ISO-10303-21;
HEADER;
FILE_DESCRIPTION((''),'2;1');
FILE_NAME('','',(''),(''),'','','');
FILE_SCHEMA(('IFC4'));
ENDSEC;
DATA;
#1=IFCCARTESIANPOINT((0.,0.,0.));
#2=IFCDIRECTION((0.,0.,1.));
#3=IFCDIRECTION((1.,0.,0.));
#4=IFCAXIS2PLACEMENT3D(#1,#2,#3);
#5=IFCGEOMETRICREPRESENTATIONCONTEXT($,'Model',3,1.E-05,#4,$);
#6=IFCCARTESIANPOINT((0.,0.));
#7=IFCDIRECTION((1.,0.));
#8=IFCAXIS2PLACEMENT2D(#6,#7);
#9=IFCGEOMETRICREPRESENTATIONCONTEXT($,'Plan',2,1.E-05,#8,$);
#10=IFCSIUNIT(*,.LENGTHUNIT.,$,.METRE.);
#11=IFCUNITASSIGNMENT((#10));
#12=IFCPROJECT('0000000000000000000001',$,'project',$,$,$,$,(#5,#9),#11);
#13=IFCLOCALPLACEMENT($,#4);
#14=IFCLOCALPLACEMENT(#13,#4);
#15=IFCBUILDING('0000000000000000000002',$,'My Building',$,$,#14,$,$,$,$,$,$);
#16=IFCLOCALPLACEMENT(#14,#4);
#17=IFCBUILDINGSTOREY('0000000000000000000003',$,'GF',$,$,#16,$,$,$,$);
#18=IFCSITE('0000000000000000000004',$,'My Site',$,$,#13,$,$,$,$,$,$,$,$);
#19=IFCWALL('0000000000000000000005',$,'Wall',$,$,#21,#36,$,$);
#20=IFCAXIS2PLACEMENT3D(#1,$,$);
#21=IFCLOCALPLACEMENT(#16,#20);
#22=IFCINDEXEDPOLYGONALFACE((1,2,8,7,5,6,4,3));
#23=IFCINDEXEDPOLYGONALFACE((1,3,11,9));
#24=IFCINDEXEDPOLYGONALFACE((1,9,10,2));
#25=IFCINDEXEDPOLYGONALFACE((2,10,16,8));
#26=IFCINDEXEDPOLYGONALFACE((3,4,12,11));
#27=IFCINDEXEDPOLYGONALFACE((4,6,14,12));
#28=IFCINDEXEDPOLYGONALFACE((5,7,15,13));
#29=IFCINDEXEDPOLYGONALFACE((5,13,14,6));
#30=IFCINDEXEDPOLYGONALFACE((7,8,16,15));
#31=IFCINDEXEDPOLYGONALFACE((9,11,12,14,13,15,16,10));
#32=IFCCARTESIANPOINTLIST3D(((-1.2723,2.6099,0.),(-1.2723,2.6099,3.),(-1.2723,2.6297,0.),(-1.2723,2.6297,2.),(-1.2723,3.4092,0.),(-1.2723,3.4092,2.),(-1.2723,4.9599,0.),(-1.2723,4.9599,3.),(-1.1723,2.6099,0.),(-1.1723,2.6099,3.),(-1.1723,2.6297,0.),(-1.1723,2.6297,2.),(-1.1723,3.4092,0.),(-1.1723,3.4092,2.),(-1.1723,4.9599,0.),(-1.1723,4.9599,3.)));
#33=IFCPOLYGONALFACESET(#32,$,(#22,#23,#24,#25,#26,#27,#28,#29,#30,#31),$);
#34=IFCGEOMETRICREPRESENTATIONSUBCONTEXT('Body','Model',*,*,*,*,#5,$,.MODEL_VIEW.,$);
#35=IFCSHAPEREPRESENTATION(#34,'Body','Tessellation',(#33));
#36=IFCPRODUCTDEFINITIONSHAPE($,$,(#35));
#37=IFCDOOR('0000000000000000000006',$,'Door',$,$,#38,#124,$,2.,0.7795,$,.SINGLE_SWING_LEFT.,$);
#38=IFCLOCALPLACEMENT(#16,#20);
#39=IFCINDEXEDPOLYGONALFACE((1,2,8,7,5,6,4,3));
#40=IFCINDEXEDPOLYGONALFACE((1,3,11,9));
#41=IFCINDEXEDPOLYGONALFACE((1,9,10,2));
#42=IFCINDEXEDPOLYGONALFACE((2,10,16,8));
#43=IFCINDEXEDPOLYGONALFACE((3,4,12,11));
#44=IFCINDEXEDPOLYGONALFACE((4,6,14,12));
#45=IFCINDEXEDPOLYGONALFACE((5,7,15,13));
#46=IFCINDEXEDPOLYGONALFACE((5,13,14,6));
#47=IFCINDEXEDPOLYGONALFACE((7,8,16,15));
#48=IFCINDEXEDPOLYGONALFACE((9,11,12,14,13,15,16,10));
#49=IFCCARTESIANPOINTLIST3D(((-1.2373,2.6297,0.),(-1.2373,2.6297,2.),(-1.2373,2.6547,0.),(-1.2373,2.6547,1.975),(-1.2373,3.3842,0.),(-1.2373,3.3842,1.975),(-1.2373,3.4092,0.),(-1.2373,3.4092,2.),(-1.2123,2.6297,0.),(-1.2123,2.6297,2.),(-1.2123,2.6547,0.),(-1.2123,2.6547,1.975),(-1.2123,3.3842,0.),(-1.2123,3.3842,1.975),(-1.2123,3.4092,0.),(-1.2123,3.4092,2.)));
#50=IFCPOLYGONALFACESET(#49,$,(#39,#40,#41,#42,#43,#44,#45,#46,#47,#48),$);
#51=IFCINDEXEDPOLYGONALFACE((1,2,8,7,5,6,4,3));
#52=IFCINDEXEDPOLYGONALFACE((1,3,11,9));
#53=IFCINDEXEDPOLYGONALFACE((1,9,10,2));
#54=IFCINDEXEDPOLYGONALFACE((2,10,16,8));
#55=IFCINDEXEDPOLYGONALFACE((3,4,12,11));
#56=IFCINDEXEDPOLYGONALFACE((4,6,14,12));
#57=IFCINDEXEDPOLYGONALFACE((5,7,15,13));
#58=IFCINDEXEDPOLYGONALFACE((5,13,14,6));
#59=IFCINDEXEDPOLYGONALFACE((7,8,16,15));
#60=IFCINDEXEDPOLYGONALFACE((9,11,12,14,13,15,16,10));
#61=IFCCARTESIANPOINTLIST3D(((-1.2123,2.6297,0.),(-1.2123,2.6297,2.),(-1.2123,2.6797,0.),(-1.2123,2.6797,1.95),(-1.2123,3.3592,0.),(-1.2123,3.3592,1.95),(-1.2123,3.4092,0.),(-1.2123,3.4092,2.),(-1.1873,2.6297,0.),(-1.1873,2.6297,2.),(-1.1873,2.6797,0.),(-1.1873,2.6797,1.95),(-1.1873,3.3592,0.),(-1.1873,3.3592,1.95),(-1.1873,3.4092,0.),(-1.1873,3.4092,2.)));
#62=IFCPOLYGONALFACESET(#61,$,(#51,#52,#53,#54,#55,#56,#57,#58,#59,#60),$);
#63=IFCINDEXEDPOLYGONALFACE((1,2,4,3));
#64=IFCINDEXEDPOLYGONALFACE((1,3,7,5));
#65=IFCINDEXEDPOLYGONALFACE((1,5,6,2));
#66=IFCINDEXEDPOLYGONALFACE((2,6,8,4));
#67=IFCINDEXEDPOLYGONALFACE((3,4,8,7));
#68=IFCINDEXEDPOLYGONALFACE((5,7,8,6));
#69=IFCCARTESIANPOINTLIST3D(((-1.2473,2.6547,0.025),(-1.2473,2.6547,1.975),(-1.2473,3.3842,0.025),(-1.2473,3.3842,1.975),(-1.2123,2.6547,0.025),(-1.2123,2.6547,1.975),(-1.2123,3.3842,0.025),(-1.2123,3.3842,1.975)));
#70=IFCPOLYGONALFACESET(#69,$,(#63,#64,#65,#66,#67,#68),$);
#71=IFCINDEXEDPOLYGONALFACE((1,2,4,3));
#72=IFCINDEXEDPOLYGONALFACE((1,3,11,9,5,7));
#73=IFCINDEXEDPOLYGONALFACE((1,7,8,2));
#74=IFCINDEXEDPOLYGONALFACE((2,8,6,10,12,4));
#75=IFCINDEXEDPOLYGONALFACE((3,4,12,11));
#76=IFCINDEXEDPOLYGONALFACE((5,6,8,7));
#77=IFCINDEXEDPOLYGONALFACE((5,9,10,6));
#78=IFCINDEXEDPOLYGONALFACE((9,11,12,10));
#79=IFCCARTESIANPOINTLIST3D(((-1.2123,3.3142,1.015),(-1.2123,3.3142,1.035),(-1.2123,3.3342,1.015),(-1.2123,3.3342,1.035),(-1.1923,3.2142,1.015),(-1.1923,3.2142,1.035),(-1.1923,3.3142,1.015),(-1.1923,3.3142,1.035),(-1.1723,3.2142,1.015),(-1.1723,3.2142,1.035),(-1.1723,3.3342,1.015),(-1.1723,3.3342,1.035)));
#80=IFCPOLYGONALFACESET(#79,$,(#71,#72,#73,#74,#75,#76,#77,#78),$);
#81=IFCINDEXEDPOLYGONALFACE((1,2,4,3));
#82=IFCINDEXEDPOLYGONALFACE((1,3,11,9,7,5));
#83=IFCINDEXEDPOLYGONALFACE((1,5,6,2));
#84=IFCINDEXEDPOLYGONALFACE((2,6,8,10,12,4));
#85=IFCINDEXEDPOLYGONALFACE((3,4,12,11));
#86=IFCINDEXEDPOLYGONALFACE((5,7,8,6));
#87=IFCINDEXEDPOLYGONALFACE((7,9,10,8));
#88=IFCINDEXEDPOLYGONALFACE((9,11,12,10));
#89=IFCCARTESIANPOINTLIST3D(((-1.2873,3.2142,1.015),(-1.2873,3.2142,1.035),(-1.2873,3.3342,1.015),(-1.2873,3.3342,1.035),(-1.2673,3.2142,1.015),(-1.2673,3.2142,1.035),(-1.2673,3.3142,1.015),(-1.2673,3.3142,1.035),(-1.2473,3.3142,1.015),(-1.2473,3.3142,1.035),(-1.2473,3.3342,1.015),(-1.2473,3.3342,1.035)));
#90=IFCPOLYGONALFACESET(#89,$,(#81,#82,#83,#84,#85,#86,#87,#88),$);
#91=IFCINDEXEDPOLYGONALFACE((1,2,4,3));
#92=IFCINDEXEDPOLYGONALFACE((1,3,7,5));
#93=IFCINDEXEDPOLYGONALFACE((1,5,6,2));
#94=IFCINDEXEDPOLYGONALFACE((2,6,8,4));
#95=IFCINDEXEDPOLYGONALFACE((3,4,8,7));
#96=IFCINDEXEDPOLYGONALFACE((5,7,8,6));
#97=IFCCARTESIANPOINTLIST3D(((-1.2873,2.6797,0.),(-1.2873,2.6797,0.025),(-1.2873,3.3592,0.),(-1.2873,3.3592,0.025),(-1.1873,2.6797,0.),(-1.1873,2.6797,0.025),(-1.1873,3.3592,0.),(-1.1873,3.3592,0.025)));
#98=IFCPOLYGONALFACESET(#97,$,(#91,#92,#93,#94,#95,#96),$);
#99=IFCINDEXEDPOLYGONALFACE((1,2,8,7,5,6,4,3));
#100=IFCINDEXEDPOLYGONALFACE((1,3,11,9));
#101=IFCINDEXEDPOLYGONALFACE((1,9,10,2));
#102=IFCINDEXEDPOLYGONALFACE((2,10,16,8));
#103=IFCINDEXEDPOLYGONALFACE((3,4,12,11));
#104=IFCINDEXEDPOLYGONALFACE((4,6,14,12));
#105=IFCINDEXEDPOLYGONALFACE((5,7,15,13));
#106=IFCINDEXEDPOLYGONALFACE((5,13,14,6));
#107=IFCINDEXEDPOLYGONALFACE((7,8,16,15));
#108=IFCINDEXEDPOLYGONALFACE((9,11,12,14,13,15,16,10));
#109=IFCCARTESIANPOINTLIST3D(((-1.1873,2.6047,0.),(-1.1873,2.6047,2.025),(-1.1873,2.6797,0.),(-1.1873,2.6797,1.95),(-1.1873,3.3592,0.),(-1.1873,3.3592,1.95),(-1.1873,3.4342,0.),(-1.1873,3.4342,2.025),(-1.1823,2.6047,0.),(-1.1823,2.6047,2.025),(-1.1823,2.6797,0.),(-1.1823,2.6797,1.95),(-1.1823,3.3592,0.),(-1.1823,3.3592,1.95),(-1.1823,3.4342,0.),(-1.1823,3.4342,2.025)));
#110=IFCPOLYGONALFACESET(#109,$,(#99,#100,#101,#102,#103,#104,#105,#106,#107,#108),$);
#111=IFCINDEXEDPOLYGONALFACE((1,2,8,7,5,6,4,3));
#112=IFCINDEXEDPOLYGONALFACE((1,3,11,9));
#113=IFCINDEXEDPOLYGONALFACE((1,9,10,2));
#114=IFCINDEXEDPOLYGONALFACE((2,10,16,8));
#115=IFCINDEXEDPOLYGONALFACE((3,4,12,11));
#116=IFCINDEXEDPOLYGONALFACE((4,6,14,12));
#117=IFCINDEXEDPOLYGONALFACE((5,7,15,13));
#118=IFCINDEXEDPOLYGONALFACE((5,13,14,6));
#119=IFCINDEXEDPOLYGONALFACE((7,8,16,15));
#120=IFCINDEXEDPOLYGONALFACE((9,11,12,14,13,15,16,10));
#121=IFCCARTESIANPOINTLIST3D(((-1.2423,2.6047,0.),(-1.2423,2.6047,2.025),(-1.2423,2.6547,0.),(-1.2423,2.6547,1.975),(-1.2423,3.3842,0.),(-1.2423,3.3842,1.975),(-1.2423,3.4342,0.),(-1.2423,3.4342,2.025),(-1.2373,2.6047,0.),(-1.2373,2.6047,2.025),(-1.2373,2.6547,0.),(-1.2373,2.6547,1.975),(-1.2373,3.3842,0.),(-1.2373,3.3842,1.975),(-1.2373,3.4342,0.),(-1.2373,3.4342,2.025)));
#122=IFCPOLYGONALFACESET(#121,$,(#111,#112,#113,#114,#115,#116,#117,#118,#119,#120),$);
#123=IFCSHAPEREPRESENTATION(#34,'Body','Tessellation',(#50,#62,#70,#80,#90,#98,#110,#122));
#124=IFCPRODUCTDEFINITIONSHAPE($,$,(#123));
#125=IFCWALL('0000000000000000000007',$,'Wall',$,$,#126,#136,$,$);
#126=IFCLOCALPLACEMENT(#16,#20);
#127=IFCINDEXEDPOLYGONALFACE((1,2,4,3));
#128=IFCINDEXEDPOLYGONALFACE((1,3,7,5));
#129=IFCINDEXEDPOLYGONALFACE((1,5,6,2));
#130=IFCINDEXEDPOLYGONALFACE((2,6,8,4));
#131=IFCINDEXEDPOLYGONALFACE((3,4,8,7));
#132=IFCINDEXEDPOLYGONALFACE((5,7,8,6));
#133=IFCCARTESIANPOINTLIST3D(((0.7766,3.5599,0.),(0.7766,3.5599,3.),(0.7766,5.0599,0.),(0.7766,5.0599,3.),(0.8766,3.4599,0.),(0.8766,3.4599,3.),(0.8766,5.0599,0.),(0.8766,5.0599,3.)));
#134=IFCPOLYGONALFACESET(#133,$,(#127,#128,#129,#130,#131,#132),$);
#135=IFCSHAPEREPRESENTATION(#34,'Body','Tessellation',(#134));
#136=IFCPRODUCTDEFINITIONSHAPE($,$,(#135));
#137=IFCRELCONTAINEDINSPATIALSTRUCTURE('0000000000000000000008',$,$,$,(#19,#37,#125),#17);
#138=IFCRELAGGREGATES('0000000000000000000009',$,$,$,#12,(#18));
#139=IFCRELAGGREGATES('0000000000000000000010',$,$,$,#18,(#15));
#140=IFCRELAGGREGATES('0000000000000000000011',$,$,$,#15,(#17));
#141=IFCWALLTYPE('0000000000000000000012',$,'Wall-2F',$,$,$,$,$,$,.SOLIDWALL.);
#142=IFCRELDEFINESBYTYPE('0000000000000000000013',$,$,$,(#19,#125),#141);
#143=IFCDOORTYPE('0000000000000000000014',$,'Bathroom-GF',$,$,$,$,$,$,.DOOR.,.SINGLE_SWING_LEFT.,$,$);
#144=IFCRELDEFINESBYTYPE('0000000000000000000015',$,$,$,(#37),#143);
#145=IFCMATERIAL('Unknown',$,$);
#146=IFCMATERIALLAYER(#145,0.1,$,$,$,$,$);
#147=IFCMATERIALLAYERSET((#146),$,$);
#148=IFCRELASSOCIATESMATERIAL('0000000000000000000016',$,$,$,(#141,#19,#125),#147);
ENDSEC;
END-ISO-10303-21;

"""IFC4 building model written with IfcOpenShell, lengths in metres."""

from ifc_helpers import new_model, entity, si_unit, frame, origin_with_axes, origin_2d_with_axis, place, context, subcontext, project, spatial, line, indexed_curve, outline, extrude, shape, source, transform, mapped, material, layer, layer_set, layer_usage, type_object, type_shapes, element, fill, save


model = new_model("IFC4")

# Units and contexts
model_context = context("Model", 3, precision=1e-05, world=origin_with_axes())
plan_context = context("Plan", 2, precision=1e-05, world=origin_2d_with_axis())
body_context_1 = subcontext(model_context, "Body", "Model", "MODEL_VIEW")
body_context_2 = subcontext(plan_context, "Body", "Plan", "PLAN_VIEW")
ifc_project = project(units=[si_unit("LENGTHUNIT", "METRE")], contexts=[model_context, plan_context])

# Site, building, storey
site_placement = place(None, origin_with_axes())
site = spatial("IfcSite", under=ifc_project, at=site_placement, Name="My Site")
building_placement = place(site_placement, origin_with_axes())
building = spatial("IfcBuilding", under=site, at=building_placement, Name="My Building")
storey_placement = place(building_placement, origin_with_axes())
storey = spatial("IfcBuildingStorey", under=building, at=storey_placement, Name="GF")

# Shared definitions
ifc_material_1 = material(Name="Unknown")

# Shared definitions
ifc_layer_1 = layer(ifc_material_1, 0.1)
ifc_layer_set_1 = layer_set([ifc_layer_1])
wall_type = type_object("IfcWallType", Name="Wall-2F", PredefinedType="SOLIDWALL", material=ifc_layer_set_1)

# Wall, opening, door
ifc_layer_usage_1 = layer_usage(ifc_layer_set_1, "AXIS2", "POSITIVE", 0.0)
wall_1_placement = place(storey_placement, frame((-1.1723, 2.6099, 0.0), z_axis=(0.0, 0.0, 1.0), x_axis=(0.0, 1.0, 0.0)))
wall_1 = element("IfcWall", 1, at=wall_1_placement, inside=storey, type_object=wall_type, material=ifc_layer_usage_1, Name="Wall", context=body_context_1, shape_type="SweptSolid", body=[
    extrude(outline(indexed_curve([(0.0, 0.0), (0.0, 0.1), (2.35, 0.1), (2.35, 0.0)], segments=[line(1, 2, 3, 4, 1)])), origin_with_axes(), (0.0, 0.0, 1.0), 3.0),
])
shared_shape_1 = source(origin_with_axes(), body_context_1, "Body", "SweptSolid", [
    extrude(outline(indexed_curve([(0.0, 0.0), (0.7795, 0.0), (0.7795, 2.0), (0.0, 2.0)], segments=[line(1, 2, 3, 4, 1)])), frame((0.0, -0.6, 0.0), z_axis=(0.0, -1.0, 0.0), x_axis=(1.0, 0.0, 0.0)), (0.0, 0.0, -1.0), 1.2),
])
opening_1_placement = place(wall_1_placement, frame((0.0198, 0.015, 0.0), z_axis=(0.0, 0.0, 1.0), x_axis=(1.0, 0.0, 0.0)))
opening_1 = element("IfcOpeningElement", 2, at=opening_1_placement, cuts=wall_1, PredefinedType="OPENING", context=body_context_1, shape_type="MappedRepresentation", body=[
    mapped(shared_shape_1, transform((0.0, 0.0, 0.0), x_axis=(1.0, 0.0, 0.0), y_axis=(0.0, 1.0, 0.0), z_axis=(0.0, 0.0, 1.0), scale=1.0)),
])
door_type_1 = type_object("IfcDoorType", Name="Bathroom-GF", OperationType="SINGLE_SWING_LEFT", PredefinedType="DOOR")
shared_shape_2 = source(origin_with_axes(), body_context_1, "Body", "SweptSolid", [
    extrude(outline(indexed_curve([(0.0, 0.0), (0.0, 2.0), (0.7795, 2.0), (0.7795, 0.0), (0.7545, 0.0), (0.7545, 1.975), (0.025, 1.975), (0.025, 0.0)], segments=[line(1, 2, 3, 4, 5, 6, 7, 8, 1)])), frame((0.0, 0.025, 0.0), z_axis=(0.0, -1.0, 0.0), x_axis=(1.0, 0.0, 0.0)), (0.0, 0.0, -1.0), 0.025),
    extrude(outline(indexed_curve([(0.0, 0.0), (0.0, 2.0), (0.7795, 2.0), (0.7795, 0.0), (0.7295, 0.0), (0.7295, 1.95), (0.05, 1.95), (0.05, 0.0)], segments=[line(1, 2, 3, 4, 5, 6, 7, 8, 1)])), frame((0.0, 0.0, 0.0), z_axis=(0.0, -1.0, 0.0), x_axis=(1.0, 0.0, 0.0)), (0.0, 0.0, -1.0), 0.025),
    extrude(outline(indexed_curve([(0.0, 0.0), (0.7295, 0.0), (0.7295, 0.035), (0.0, 0.035)], segments=[line(1, 2, 3, 4, 1)])), frame((0.025, 0.025, 0.025), z_axis=(0.0, 0.0, 1.0), x_axis=(1.0, 0.0, 0.0)), (0.0, 0.0, 1.0), 1.95),
    extrude(outline(indexed_curve([(0.0, 0.0), (0.0, -0.04), (-0.12, -0.04), (-0.12, -0.02), (-0.02, -0.02), (-0.02, 0.0)], segments=[line(1, 2, 3, 4, 5, 6, 1)])), frame((0.7045, 0.025, 1.015), z_axis=(0.0, 0.0, 1.0), x_axis=(1.0, 0.0, 0.0)), (0.0, 0.0, 1.0), 0.02),
    extrude(outline(indexed_curve([(0.0, 0.0), (0.0, 0.04), (-0.12, 0.04), (-0.12, 0.02), (-0.02, 0.02), (-0.02, 0.0)], segments=[line(1, 2, 3, 4, 5, 6, 1)])), frame((0.7045, 0.06, 1.015), z_axis=(0.0, 0.0, 1.0), x_axis=(1.0, 0.0, 0.0)), (0.0, 0.0, 1.0), 0.02),
    extrude(outline(indexed_curve([(0.0, 0.0), (0.6795, 0.0), (0.6795, 0.1), (0.0, 0.1)], segments=[line(1, 2, 3, 4, 1)])), frame((0.05, 0.0, 0.0), z_axis=(0.0, 0.0, 1.0), x_axis=(1.0, 0.0, 0.0)), (0.0, 0.0, 1.0), 0.025),
    extrude(outline(indexed_curve([(0.0, 0.0), (0.0, 2.025), (0.8295, 2.025), (0.8295, 0.0), (0.7545, 0.0), (0.7545, 1.95), (0.075, 1.95), (0.075, 0.0)], segments=[line(1, 2, 3, 4, 5, 6, 7, 8, 1)])), frame((-0.025, -0.005, 0.0), z_axis=(0.0, -1.0, 0.0), x_axis=(1.0, 0.0, 0.0)), (0.0, 0.0, -1.0), 0.005),
    extrude(outline(indexed_curve([(0.0, 0.0), (0.0, 2.025), (0.8295, 2.025), (0.8295, 0.0), (0.7795, 0.0), (0.7795, 1.975), (0.05, 1.975), (0.05, 0.0)], segments=[line(1, 2, 3, 4, 5, 6, 7, 8, 1)])), frame((-0.025, 0.05, 0.0), z_axis=(0.0, -1.0, 0.0), x_axis=(1.0, 0.0, 0.0)), (0.0, 0.0, -1.0), 0.005),
])
shared_shape_3 = source(origin_with_axes(), body_context_2, "Body", "Curve2D", [
    entity("IfcIndexedPolyCurve", entity("IfcCartesianPointList2D", [[0.0, 0.0], [0.0, 0.05], [0.025, 0.05], [0.025, 0.025], [0.05, 0.025], [0.05, 0.0]]), [entity("IfcLineIndex", [1, 2, 3, 4, 5, 6, 1])]),
    entity("IfcIndexedPolyCurve", entity("IfcCartesianPointList2D", [[0.7795, 0.0], [0.7795, 0.05], [0.7545, 0.05], [0.7545, 0.025], [0.7295, 0.025], [0.7295, 0.0]]), [entity("IfcLineIndex", [1, 2, 3, 4, 5, 6, 1])]),
    entity("IfcTrimmedCurve", entity("IfcEllipse", entity("IfcAxis2Placement2D", entity("IfcCartesianPoint", [0.06, 0.05]), entity("IfcDirection", [1.0, 0.0])), 0.6945, 0.7295), [entity("IfcCartesianPoint", [0.7545, 0.05])], [entity("IfcCartesianPoint", [0.06, 0.7795])], True, "CARTESIAN"),
    entity("IfcIndexedPolyCurve", entity("IfcCartesianPointList2D", [[0.025, 0.05], [0.06, 0.05], [0.06, 0.7795], [0.025, 0.7795]]), [entity("IfcLineIndex", [1, 2, 3, 4, 1])]),
])
type_shapes(door_type_1, [shared_shape_2, shared_shape_3])
door_1_placement = place(opening_1_placement, frame((0.0, 0.0, 0.0), z_axis=(0.0, 0.0, 1.0), x_axis=(1.0, 0.0, 0.0)))
door_1 = element("IfcDoor", 3, at=door_1_placement, inside=storey, type_object=door_type_1, Name="Door", OperationType="SINGLE_SWING_LEFT", OverallHeight=2.0, OverallWidth=0.7795, shapes=[
    shape(body_context_1, "Body", "MappedRepresentation", [mapped(shared_shape_2, transform((0.0, 0.0, 0.0), x_axis=(1.0, 0.0, 0.0), y_axis=(0.0, 1.0, 0.0), z_axis=(0.0, 0.0, 1.0), scale=1.0))]),
    shape(body_context_2, "Body", "MappedRepresentation", [mapped(shared_shape_3, transform((0.0, 0.0, 0.0), x_axis=(1.0, 0.0, 0.0), y_axis=(0.0, 1.0, 0.0), z_axis=(0.0, 0.0, 1.0), scale=1.0))]),
])
fill(opening_1, door_1)

# Wall
ifc_layer_usage_2 = layer_usage(ifc_layer_set_1, "AXIS2", "POSITIVE", 0.0)
wall_2_placement = place(storey_placement, frame((0.7766, 5.0599, 0.0), z_axis=(0.0, 0.0, 1.0), x_axis=(0.0, -1.0, 0.0)))
element("IfcWall", 4, at=wall_2_placement, inside=storey, type_object=wall_type, material=ifc_layer_usage_2, Name="Wall", context=body_context_1, shape_type="SweptSolid", body=[
    extrude(outline(indexed_curve([(0.0, 0.0), (0.0, 0.1), (1.6, 0.1), (1.5, 0.0)], segments=[line(1, 2, 3, 4, 1)])), origin_with_axes(), (0.0, 0.0, 1.0), 3.0),
])

save(model, "model.ifc")
